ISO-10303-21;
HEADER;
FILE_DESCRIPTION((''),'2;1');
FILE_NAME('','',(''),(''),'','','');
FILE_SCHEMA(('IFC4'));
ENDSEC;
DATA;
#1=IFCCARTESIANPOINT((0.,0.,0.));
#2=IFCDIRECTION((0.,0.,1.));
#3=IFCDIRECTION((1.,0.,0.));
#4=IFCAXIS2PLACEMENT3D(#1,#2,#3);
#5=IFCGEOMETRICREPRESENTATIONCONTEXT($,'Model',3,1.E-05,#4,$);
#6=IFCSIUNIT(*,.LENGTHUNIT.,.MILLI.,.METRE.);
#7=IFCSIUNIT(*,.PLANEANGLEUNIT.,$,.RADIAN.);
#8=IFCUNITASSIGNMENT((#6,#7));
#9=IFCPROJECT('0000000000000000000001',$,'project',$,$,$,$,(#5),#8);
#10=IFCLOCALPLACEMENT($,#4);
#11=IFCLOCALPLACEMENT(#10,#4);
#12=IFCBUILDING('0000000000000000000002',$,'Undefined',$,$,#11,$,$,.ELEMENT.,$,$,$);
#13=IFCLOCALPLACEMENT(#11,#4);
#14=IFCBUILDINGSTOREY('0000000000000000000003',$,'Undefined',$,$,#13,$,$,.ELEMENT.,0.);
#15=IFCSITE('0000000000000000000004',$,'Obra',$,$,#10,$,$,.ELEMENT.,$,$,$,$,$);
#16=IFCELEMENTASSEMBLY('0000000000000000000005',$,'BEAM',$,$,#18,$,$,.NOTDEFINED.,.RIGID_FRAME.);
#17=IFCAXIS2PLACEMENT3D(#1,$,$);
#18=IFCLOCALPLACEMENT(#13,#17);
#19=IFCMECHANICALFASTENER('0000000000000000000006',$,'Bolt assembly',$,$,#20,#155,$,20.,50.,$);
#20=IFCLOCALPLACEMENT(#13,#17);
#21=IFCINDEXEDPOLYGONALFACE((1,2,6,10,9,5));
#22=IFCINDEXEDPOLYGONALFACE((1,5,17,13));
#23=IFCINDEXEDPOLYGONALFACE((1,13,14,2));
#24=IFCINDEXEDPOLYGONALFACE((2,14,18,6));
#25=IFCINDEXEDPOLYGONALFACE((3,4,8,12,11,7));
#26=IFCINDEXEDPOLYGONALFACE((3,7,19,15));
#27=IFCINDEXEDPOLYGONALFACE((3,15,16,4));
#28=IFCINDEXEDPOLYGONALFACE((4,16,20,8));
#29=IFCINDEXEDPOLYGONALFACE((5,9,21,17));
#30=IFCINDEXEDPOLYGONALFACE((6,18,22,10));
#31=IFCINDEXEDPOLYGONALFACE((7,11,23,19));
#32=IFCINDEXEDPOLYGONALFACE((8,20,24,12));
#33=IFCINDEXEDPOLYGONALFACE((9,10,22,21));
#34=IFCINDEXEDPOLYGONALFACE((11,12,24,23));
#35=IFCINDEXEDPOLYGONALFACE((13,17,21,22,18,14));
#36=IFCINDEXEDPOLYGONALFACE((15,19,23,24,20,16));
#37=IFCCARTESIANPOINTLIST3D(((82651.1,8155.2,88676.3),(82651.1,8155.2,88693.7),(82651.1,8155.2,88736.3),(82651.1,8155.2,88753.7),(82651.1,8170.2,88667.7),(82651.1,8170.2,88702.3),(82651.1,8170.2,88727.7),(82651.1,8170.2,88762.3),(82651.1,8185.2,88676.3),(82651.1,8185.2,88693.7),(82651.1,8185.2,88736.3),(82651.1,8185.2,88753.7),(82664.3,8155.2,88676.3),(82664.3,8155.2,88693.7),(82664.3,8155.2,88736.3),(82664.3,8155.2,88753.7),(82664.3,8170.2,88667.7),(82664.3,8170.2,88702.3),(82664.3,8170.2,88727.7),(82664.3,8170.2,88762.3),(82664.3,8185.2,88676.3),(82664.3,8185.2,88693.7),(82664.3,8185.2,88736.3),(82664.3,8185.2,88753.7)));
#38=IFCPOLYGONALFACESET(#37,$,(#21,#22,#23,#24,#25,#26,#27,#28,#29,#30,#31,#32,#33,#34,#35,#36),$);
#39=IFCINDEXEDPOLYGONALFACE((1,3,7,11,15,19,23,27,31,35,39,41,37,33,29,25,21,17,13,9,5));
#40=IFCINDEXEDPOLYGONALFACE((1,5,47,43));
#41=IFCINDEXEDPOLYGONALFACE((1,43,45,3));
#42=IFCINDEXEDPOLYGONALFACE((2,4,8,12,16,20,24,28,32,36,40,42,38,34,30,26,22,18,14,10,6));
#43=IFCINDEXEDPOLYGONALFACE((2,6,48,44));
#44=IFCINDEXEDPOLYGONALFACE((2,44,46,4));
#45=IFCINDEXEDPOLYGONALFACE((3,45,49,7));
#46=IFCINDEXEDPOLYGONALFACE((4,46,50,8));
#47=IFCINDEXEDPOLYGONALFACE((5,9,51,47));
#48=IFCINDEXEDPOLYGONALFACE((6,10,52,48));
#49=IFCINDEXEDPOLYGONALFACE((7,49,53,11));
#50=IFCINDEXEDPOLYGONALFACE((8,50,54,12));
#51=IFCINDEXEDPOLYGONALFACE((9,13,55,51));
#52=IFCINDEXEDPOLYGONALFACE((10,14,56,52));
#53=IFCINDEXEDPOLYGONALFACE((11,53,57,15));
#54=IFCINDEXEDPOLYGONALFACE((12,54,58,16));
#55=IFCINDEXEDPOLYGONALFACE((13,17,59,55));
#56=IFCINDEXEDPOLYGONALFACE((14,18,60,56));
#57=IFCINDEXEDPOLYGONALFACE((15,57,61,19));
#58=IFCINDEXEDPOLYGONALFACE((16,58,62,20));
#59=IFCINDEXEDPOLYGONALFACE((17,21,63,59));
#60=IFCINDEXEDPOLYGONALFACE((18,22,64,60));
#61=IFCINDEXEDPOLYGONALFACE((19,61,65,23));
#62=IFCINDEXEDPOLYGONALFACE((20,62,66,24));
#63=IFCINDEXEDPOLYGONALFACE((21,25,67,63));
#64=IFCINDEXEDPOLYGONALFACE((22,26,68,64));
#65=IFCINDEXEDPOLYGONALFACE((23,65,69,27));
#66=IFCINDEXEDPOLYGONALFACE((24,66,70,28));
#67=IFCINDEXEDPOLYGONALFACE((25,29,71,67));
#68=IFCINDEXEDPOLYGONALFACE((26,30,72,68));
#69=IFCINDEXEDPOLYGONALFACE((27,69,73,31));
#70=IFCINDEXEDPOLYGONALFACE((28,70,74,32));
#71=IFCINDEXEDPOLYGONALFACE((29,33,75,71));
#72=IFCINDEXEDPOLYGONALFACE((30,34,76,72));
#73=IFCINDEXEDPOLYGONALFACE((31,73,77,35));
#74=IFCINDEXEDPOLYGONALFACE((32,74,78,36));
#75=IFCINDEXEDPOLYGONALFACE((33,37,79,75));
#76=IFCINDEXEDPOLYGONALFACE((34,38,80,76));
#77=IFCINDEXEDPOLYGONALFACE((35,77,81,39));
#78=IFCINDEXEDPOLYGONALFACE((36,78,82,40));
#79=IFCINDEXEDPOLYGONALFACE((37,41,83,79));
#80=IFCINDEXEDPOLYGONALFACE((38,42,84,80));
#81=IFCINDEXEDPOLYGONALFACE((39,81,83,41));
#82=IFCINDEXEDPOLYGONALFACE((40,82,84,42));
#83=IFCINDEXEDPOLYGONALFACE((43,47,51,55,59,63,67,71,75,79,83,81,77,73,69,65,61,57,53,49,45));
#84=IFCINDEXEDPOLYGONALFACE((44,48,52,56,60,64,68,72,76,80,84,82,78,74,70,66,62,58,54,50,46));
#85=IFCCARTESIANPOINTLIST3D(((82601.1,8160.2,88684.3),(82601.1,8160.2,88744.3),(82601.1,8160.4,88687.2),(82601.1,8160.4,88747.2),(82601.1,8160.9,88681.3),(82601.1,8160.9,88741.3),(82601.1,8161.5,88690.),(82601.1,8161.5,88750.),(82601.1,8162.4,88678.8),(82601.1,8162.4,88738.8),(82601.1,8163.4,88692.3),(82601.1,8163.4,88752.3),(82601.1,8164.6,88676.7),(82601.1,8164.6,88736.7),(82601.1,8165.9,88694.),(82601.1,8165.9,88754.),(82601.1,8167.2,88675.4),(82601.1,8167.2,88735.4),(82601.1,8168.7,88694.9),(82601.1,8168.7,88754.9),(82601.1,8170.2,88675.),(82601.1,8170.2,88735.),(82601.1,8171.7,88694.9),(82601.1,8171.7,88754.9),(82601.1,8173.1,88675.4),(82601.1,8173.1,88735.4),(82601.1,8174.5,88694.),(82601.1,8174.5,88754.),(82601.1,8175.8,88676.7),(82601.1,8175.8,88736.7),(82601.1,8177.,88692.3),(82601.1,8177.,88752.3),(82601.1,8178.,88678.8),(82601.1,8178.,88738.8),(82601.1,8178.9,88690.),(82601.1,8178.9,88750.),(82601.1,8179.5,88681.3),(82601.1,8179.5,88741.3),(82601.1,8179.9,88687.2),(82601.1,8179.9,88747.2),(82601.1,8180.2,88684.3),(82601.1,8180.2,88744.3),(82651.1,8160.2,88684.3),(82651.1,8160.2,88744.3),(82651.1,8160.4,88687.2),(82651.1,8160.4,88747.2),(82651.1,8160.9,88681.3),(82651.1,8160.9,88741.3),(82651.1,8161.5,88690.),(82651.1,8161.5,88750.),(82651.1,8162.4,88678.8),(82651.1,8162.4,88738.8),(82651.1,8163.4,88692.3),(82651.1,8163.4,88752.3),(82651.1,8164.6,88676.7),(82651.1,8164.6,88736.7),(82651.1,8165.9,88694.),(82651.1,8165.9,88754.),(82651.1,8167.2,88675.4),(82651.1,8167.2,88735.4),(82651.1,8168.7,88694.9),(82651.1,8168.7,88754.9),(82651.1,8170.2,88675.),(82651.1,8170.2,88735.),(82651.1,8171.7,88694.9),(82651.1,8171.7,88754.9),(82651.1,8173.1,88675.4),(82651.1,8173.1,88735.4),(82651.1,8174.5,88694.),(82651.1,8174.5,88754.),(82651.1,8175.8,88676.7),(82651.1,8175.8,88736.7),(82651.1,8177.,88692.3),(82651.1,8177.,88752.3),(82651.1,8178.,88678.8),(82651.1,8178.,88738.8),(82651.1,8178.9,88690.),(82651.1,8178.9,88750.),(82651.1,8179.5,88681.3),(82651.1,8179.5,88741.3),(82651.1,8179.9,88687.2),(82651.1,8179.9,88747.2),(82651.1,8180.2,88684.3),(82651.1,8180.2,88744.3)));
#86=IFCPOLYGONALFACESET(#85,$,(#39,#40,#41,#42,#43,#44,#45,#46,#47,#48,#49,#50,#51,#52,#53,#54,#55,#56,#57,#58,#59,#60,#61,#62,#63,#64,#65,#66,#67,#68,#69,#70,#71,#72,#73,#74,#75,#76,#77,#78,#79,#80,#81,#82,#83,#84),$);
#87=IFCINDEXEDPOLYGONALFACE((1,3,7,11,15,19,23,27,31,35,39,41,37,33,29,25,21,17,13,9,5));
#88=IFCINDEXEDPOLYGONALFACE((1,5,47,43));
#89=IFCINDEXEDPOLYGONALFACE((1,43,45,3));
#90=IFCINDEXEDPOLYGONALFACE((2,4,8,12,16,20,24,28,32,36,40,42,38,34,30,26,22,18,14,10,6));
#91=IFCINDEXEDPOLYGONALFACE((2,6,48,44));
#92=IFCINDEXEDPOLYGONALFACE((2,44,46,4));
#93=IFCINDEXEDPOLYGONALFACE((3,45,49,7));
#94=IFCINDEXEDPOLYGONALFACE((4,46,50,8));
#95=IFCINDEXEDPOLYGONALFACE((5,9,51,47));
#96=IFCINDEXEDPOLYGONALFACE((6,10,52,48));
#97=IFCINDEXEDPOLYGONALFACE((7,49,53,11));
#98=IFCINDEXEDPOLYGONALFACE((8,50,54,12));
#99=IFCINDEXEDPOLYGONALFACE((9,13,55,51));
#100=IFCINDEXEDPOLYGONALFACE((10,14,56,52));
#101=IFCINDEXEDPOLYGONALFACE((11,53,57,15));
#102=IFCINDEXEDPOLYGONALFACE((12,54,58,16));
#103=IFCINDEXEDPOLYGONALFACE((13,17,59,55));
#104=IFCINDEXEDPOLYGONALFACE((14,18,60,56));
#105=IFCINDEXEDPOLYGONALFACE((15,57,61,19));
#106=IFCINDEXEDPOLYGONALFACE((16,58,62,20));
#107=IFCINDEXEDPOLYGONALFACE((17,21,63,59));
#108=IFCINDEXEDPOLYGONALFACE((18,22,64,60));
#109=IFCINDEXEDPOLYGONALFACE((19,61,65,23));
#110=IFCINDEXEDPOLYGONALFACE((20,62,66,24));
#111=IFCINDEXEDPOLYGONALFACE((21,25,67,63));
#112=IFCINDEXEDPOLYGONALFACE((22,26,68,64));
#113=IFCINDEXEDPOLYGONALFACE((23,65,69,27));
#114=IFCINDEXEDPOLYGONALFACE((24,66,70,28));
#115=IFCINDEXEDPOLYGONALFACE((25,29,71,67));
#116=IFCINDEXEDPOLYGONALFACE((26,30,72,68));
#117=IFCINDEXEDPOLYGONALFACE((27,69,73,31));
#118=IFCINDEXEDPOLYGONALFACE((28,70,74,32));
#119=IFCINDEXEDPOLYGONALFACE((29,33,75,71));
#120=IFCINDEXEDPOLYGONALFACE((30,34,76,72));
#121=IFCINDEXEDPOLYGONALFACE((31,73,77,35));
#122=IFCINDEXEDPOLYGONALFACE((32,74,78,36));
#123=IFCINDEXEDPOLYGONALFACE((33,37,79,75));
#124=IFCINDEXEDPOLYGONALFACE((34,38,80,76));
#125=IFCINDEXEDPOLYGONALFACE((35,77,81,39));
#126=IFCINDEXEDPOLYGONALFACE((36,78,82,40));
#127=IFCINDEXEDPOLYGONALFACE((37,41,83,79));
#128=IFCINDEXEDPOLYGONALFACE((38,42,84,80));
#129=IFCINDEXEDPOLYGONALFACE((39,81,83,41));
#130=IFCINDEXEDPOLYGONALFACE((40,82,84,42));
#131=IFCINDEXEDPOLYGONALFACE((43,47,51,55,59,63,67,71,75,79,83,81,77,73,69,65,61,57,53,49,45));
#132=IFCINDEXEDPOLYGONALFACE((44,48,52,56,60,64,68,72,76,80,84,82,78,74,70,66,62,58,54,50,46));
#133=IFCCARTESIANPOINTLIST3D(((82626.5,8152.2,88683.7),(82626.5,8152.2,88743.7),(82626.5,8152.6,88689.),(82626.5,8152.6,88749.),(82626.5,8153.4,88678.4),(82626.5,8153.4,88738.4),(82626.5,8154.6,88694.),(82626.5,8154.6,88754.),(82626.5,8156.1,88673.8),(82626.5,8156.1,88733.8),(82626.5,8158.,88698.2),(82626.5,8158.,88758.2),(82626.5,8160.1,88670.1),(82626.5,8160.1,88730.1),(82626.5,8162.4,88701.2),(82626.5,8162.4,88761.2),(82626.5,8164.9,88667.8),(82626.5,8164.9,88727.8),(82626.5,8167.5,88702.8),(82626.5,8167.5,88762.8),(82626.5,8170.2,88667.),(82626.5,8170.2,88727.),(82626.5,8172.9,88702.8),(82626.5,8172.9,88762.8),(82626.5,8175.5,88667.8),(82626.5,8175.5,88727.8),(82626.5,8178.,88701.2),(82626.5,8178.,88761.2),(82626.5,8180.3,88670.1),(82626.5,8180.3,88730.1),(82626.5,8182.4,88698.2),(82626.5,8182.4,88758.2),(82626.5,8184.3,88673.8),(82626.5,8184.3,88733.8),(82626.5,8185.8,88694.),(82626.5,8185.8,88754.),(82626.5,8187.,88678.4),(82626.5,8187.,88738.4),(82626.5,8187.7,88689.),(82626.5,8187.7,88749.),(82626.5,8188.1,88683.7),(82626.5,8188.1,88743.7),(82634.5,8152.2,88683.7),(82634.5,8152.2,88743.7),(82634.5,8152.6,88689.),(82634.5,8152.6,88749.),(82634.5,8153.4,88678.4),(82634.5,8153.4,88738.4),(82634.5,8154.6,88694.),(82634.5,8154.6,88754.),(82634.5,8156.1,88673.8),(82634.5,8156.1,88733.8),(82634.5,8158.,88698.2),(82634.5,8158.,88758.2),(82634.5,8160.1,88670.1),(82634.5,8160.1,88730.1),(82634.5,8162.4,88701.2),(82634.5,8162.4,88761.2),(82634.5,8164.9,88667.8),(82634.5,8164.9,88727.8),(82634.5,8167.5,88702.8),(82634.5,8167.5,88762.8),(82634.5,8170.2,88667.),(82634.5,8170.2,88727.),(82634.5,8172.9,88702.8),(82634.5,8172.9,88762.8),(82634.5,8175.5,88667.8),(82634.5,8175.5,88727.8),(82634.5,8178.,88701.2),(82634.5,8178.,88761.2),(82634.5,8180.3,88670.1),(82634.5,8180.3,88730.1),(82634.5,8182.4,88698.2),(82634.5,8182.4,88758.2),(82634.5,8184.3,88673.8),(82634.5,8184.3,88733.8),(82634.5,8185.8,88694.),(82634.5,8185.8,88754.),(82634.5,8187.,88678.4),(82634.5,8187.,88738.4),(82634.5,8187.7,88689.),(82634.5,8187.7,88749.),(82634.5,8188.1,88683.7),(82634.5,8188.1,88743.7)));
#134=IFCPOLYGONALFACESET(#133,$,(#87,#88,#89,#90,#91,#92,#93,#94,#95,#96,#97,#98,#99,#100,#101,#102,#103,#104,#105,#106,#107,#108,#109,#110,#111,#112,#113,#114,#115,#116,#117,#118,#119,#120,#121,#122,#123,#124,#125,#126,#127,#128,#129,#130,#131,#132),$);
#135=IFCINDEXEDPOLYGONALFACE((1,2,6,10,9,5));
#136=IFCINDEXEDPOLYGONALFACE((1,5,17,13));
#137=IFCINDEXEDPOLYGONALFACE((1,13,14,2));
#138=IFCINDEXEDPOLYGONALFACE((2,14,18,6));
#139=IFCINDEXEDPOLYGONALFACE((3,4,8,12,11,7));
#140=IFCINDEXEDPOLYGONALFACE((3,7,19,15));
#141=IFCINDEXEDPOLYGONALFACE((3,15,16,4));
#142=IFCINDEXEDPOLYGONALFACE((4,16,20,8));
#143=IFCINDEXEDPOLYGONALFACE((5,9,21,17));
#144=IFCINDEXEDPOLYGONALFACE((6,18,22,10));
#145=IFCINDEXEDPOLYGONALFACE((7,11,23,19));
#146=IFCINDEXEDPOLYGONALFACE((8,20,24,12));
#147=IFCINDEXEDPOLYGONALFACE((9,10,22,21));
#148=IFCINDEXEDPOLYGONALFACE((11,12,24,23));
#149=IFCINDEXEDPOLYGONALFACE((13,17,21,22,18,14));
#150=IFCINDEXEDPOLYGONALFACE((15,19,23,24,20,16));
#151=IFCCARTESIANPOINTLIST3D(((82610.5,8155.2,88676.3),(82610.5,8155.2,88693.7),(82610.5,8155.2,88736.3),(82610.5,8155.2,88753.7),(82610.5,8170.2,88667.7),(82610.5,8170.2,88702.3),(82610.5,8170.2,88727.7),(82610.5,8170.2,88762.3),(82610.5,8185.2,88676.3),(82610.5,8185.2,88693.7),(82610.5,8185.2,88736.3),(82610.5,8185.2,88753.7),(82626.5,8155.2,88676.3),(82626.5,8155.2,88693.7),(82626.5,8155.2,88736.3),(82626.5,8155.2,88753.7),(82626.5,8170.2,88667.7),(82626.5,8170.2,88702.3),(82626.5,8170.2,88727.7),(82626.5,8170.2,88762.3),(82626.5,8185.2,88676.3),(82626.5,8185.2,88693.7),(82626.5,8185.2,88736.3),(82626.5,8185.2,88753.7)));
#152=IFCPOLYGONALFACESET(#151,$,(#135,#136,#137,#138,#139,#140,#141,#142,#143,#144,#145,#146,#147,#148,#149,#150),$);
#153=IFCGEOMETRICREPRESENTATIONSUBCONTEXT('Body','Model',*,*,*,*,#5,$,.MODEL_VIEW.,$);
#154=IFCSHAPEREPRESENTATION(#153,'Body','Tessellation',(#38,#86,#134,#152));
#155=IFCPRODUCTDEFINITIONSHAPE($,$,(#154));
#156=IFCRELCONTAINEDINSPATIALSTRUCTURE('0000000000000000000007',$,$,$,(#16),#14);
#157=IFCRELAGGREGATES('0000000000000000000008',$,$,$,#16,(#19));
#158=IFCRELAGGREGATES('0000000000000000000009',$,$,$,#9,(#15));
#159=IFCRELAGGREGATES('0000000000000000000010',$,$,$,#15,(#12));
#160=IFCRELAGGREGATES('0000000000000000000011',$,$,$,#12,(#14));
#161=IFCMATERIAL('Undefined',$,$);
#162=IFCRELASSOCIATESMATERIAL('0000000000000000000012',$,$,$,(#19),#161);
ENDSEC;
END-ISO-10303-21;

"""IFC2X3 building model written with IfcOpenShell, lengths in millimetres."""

from ifc_helpers import new_model, si_unit, frame, origin_with_axes, origin_2d_with_axis, place, context, subcontext, project, spatial, polyline, circle, outline, extrude, source, transform, mapped, material, element, aggregate, save


model = new_model("IFC2X3")

# Units and contexts
model_context = context("Model", 3, precision=1e-05, world=origin_with_axes())
body_context = subcontext(model_context, "Body", "Model", "MODEL_VIEW")
ifc_project = project(units=[si_unit("LENGTHUNIT", "METRE", prefix="MILLI"), si_unit("PLANEANGLEUNIT", "RADIAN")], contexts=[model_context])

# Site, building, storey
site_placement = place(None, origin_with_axes())
site = spatial("IfcSite", under=ifc_project, at=site_placement, Name="Obra", CompositionType="ELEMENT")
building_placement = place(site_placement, origin_with_axes())
building = spatial("IfcBuilding", under=site, at=building_placement, Name="Undefined", CompositionType="ELEMENT")
storey_placement = place(building_placement, origin_with_axes())
storey = spatial("IfcBuildingStorey", under=building, at=storey_placement, Name="Undefined", CompositionType="ELEMENT", Elevation=0.0)

# Shared definitions
ifc_material_1 = material(Name="Undefined")

# Element assembly, mechanical fastener
assembly_1_placement = place(storey_placement, origin_with_axes())
assembly_1 = element("IfcElementAssembly", 1, at=assembly_1_placement, inside=storey, Name="BEAM", AssemblyPlace="NOTDEFINED", PredefinedType="RIGID_FRAME")
shared_shape_1 = source(origin_with_axes(), body_context, "Body", "SweptSolid", [
    extrude(outline(polyline([(17.3, 0.0), (8.7, 15.0), (-8.7, 15.0), (-17.3, 0.0), (-8.7, -15.0), (8.7, -15.0), (17.3, 0.0)])), frame((0.0, -26.5, 0.0), z_axis=(0.0, 1.0, 0.0), x_axis=(1.0, 0.0, 0.0)), (0.0, 0.0, 1.0), 13.2),
    extrude(circle(Radius=10.0, at=origin_2d_with_axis()), frame((0.0, -13.3, 0.0), z_axis=(0.0, 1.0, 0.0), x_axis=(1.0, 0.0, 0.0)), (0.0, 0.0, 1.0), 50.0),
    extrude(circle(Radius=18.0, at=origin_2d_with_axis()), frame((0.0, 3.3, 0.0), z_axis=(0.0, 1.0, 0.0), x_axis=(1.0, 0.0, 0.0)), (0.0, 0.0, 1.0), 8.0),
    extrude(outline(polyline([(17.3, 0.0), (8.7, 15.0), (-8.7, 15.0), (-17.3, 0.0), (-8.7, -15.0), (8.7, -15.0), (17.3, 0.0)])), frame((0.0, 11.3, 0.0), z_axis=(0.0, 1.0, 0.0), x_axis=(1.0, 0.0, 0.0)), (0.0, 0.0, 1.0), 16.0),
])
mechanical_fastener_1_placement = place(assembly_1_placement, frame((82637.8, 8130.2, 88850.0), z_axis=(0.0, 1.0, 0.0), x_axis=(0.0, 0.0, -1.0)))
mechanical_fastener_1 = element("IfcMechanicalFastener", 2, at=mechanical_fastener_1_placement, material=ifc_material_1, Name="Bolt assembly", NominalDiameter=20.0, NominalLength=50.0, context=body_context, shape_type="MappedRepresentation", body=[
    mapped(shared_shape_1, transform((105.0, 0.0, 40.0))),
    mapped(shared_shape_1, transform((165.0, 0.0, 40.0))),
])
aggregate(assembly_1, [mechanical_fastener_1])

save(model, "model.ifc")
